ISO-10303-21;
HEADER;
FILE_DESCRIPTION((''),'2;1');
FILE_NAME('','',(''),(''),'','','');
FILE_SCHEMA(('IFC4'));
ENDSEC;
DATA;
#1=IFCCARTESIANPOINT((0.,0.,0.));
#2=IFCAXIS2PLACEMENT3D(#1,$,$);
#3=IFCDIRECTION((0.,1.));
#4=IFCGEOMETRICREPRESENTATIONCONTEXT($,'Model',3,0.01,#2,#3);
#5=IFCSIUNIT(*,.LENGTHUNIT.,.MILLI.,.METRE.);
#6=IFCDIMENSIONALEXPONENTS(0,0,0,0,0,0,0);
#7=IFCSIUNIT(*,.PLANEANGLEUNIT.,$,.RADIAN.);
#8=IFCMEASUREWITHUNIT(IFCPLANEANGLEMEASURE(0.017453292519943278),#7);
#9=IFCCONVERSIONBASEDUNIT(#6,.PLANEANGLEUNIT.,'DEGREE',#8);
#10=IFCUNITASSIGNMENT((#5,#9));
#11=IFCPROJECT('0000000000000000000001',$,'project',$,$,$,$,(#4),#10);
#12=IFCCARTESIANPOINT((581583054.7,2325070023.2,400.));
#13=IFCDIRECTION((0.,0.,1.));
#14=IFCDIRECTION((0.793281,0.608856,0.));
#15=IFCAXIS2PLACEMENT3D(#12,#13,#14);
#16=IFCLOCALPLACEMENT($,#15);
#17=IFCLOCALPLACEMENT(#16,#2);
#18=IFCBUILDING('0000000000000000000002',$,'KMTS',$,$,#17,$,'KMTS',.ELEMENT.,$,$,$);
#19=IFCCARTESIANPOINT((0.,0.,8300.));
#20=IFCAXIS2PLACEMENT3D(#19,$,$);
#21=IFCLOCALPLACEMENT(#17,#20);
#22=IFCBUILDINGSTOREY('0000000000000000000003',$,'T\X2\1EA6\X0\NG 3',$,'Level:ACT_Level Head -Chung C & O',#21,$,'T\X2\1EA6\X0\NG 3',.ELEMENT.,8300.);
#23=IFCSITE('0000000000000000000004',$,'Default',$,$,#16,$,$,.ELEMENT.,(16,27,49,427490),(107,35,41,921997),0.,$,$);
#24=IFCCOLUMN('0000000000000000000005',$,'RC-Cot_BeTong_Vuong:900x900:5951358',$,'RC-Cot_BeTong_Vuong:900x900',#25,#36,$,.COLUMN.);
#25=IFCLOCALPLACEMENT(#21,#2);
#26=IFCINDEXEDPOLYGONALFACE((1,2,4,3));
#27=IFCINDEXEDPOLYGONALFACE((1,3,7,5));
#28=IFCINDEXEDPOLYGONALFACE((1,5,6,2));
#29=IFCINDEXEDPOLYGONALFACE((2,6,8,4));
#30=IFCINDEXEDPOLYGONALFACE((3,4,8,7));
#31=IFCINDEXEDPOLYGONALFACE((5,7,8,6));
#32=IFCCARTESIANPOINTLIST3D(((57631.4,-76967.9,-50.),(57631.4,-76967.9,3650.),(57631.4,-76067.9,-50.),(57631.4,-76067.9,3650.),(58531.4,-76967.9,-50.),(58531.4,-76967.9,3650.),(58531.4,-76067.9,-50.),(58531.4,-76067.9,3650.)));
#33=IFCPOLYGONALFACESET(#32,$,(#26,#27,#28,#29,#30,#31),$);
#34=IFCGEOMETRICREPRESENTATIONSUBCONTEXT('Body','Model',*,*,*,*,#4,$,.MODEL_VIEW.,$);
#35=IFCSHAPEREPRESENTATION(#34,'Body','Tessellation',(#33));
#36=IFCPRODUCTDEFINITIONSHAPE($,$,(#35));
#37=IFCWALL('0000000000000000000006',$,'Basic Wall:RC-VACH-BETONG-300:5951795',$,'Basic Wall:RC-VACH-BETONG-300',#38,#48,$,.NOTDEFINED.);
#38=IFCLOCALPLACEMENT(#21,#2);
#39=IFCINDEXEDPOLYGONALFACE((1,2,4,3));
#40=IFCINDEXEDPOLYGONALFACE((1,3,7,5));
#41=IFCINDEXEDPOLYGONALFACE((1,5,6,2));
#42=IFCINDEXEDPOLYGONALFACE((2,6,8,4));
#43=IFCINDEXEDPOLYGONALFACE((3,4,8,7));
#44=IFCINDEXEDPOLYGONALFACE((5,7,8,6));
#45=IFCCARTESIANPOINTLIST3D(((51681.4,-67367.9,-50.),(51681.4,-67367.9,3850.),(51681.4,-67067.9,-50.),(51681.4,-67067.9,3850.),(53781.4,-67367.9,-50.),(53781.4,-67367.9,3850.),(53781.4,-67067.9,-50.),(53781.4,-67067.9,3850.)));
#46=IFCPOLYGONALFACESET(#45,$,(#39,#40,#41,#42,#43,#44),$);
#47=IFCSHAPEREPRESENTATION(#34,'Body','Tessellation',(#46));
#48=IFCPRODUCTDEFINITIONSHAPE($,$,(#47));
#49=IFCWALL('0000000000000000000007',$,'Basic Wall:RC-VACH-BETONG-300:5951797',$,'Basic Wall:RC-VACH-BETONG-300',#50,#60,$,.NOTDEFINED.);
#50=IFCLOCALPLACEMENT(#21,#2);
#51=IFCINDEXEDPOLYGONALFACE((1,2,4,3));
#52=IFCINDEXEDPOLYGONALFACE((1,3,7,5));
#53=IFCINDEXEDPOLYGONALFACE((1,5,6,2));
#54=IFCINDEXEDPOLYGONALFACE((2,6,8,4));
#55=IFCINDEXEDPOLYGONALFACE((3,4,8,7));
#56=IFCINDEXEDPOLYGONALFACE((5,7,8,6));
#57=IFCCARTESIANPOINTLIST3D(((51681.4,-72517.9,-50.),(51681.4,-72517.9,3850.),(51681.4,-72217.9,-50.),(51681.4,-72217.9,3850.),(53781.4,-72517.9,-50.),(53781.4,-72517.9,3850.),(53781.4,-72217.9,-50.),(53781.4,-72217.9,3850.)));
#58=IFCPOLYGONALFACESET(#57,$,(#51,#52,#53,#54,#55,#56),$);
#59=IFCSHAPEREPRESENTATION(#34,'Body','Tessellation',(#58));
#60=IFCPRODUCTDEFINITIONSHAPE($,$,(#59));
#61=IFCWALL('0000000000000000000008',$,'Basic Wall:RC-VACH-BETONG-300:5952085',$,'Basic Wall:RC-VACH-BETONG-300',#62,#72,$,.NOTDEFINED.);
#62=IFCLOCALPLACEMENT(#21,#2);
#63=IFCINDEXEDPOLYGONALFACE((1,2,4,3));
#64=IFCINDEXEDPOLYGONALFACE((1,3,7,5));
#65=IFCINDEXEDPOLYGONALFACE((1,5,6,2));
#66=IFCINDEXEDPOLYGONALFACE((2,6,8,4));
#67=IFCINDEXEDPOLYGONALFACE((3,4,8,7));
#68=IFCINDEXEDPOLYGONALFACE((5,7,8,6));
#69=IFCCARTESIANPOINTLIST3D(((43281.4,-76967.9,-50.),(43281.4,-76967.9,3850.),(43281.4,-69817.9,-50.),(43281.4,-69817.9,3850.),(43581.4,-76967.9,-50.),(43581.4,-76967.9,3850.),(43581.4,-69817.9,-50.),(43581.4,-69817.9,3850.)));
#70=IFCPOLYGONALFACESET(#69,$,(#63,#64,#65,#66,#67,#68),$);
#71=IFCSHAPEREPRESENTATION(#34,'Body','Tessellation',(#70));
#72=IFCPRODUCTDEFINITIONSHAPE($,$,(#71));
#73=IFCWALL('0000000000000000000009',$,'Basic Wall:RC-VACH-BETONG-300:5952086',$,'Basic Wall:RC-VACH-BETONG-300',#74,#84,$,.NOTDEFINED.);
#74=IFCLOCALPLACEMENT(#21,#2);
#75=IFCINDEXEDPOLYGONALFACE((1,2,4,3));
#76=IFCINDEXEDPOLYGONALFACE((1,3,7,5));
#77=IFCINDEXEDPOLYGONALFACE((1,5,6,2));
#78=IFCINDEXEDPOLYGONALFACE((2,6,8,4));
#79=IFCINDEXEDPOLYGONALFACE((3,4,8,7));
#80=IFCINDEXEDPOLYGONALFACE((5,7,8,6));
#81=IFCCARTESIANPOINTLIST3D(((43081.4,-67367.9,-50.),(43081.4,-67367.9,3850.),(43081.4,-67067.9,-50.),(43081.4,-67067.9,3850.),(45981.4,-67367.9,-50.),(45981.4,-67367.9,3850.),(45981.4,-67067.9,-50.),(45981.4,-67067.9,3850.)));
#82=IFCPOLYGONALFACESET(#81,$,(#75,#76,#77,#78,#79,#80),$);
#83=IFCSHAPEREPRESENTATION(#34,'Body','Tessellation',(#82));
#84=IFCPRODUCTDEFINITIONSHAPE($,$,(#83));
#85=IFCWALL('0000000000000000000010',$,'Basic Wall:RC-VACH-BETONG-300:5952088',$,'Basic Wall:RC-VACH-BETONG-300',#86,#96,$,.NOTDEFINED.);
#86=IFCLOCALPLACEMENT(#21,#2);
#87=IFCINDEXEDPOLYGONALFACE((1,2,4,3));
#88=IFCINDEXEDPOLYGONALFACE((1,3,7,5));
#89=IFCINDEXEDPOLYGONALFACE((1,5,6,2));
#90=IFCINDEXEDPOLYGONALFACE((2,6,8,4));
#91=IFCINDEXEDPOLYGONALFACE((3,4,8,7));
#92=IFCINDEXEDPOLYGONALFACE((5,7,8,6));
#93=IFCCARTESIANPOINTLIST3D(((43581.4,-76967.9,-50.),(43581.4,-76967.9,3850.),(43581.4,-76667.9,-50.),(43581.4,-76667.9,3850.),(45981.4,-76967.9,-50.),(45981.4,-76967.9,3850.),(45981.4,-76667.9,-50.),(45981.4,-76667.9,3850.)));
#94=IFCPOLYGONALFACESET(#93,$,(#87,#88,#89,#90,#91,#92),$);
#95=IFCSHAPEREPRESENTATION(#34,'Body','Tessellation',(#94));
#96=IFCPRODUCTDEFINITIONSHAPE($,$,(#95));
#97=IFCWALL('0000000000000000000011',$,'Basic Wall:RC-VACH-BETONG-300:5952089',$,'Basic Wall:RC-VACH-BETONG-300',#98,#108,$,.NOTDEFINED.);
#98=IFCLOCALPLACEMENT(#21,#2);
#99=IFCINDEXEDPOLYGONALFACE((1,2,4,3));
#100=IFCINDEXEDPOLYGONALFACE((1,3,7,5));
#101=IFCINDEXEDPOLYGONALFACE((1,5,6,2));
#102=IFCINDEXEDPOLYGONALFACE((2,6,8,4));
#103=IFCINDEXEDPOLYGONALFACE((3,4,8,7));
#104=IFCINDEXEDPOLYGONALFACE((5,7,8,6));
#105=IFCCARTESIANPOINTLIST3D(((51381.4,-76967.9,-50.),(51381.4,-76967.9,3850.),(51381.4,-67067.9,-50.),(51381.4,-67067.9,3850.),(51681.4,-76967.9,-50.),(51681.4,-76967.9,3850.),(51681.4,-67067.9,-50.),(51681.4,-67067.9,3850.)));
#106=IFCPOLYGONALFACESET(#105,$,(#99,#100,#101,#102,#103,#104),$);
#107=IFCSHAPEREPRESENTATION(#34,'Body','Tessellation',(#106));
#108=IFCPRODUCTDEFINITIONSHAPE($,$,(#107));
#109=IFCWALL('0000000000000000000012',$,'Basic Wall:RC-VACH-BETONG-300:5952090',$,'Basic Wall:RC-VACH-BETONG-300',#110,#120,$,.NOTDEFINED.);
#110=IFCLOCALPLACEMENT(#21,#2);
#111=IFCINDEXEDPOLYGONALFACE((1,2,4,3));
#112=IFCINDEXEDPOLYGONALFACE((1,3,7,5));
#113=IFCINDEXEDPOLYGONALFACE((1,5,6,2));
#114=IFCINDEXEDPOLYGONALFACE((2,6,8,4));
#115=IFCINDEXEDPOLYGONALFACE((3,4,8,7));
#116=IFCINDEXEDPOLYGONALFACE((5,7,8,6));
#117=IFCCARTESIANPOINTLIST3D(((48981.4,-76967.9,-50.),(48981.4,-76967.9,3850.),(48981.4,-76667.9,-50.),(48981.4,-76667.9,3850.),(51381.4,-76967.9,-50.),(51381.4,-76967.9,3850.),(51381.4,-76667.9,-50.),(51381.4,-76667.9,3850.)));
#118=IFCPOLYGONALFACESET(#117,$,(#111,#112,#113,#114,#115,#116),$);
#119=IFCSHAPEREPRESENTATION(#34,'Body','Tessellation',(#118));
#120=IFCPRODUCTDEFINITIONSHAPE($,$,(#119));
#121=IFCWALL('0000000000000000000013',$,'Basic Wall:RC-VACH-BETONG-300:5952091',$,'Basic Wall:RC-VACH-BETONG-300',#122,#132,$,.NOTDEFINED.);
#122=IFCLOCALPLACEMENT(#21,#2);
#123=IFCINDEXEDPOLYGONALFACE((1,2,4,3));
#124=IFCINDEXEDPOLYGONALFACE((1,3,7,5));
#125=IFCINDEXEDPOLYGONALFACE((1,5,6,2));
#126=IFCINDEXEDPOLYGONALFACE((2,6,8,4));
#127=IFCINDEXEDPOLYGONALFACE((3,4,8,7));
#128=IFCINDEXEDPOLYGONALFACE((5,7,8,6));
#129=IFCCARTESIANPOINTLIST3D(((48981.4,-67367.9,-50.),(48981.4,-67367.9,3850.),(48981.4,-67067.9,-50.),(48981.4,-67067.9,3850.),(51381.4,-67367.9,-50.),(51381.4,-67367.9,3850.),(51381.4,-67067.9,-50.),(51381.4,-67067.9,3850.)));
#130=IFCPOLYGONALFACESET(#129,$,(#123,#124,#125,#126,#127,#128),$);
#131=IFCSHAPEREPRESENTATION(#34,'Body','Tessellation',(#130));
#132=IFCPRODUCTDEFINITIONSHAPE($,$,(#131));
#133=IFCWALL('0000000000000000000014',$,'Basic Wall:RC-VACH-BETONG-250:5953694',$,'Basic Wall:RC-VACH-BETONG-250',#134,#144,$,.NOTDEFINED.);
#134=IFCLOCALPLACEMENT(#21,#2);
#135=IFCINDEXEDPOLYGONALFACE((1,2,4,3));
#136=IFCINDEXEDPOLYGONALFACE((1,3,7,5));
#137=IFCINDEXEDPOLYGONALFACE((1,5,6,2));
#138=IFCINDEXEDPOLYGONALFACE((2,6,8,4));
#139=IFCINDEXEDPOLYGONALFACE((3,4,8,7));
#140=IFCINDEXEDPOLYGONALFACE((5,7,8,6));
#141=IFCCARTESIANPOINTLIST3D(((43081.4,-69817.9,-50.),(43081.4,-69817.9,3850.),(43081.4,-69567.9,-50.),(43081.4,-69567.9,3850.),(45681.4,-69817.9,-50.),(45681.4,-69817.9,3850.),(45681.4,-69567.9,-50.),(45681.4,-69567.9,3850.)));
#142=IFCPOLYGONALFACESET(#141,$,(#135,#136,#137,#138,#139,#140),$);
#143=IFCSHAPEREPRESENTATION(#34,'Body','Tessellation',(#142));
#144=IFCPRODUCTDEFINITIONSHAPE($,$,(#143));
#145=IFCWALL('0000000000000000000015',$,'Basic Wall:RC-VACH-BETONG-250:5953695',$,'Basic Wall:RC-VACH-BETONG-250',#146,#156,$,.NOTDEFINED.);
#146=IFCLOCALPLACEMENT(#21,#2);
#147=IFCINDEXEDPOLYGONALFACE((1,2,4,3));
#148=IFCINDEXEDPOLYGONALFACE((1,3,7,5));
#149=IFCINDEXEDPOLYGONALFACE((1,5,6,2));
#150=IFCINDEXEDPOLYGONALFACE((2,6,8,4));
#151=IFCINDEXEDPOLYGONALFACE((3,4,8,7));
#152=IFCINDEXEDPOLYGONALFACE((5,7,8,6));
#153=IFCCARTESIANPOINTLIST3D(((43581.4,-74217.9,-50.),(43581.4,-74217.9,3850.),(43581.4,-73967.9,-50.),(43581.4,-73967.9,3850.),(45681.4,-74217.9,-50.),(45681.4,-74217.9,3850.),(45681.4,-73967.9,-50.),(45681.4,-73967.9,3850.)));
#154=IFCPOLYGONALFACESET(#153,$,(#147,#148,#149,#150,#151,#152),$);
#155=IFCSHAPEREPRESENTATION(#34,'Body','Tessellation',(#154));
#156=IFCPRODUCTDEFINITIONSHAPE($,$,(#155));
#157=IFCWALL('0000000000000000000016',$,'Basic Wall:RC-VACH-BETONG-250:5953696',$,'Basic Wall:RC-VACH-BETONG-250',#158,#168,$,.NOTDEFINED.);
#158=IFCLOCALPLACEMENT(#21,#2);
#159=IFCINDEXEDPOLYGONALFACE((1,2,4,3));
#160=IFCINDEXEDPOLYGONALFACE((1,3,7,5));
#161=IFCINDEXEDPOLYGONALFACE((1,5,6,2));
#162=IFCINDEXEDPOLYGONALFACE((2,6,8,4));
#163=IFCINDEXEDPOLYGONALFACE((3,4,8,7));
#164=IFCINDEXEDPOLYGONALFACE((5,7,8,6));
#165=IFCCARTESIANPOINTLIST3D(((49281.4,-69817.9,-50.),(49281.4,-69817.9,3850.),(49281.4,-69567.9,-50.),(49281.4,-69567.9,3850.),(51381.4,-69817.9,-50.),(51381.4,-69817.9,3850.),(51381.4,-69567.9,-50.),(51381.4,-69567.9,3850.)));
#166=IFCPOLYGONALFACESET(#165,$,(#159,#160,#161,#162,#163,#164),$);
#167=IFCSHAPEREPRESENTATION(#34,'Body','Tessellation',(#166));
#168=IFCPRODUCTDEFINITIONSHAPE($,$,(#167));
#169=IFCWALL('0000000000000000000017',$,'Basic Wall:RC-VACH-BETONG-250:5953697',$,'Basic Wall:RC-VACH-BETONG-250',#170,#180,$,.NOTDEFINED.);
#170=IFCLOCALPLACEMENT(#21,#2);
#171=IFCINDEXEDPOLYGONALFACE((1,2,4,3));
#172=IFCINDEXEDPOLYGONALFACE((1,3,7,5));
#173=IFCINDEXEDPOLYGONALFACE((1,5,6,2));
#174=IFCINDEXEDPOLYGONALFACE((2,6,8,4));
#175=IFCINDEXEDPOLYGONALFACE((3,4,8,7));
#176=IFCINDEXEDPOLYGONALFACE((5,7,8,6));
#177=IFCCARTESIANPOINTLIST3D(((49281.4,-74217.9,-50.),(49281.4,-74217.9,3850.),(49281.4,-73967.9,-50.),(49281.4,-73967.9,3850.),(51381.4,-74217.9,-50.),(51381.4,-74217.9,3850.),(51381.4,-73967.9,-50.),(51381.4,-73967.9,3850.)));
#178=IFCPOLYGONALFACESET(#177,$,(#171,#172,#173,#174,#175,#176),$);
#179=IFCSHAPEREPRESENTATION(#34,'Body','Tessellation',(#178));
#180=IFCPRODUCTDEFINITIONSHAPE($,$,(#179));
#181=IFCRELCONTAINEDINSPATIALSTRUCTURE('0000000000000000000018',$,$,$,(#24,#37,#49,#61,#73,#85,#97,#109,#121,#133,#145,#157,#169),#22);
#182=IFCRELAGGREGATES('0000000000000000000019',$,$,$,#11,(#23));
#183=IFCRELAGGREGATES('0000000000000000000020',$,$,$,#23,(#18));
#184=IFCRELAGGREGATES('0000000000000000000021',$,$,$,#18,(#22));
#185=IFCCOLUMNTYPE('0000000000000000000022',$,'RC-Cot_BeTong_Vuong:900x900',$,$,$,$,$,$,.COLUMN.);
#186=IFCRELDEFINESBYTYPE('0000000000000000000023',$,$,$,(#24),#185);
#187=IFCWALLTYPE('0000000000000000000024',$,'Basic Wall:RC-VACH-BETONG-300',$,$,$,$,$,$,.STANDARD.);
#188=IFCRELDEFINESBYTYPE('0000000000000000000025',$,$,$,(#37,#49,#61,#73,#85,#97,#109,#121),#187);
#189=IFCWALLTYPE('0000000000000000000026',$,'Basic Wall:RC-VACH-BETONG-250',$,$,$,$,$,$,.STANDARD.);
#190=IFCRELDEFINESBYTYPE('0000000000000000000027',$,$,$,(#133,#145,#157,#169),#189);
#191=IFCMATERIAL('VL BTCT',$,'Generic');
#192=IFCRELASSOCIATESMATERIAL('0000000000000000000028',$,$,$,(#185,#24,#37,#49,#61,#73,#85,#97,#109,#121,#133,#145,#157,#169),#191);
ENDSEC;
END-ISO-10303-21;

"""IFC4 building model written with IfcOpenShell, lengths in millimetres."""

from ifc_helpers import new_model, entity, si_unit, converted_unit, direction, frame, origin, place, context, subcontext, project, spatial, indexed_curve, outline, extrude, source, transform, mapped, material, type_object, type_shapes, element, save


model = new_model("IFC4")

# Units and contexts
model_context = context("Model", 3, precision=0.01, world=origin(), true_north=direction((0.0, 1.0)))
body_context = subcontext(model_context, "Body", "Model", "MODEL_VIEW")
ifc_project = project(units=[si_unit("LENGTHUNIT", "METRE", prefix="MILLI"), converted_unit("PLANEANGLEUNIT", "DEGREE", entity("IfcPlaneAngleMeasure", 0.017453292519943278), si_unit("PLANEANGLEUNIT", "RADIAN"), dimensions=[0, 0, 0, 0, 0, 0, 0])], contexts=[model_context])

# Site, building, storey
site_placement = place(None, frame((581583054.7, 2325070023.2, 400.0), z_axis=(0.0, 0.0, 1.0), x_axis=(0.793281, 0.608856, 0.0)))
site = spatial("IfcSite", under=ifc_project, at=site_placement, Name="Default", CompositionType="ELEMENT", RefLatitude=(16, 27, 49, 427490), RefLongitude=(107, 35, 41, 921997), RefElevation=0.0)
building_placement = place(site_placement, origin())
building = spatial("IfcBuilding", under=site, at=building_placement, Name="KMTS", LongName="KMTS", CompositionType="ELEMENT")
storey_placement = place(building_placement, frame((0.0, 0.0, 8300.0)))
storey = spatial("IfcBuildingStorey", under=building, at=storey_placement, Name="TẦNG 3", ObjectType="Level:ACT_Level Head -Chung C & O", LongName="TẦNG 3", CompositionType="ELEMENT", Elevation=8300.0)

# Column
ifc_material_1 = material(Name="VL BTCT", Category="Generic")
column_type_1 = type_object("IfcColumnType", Name="RC-Cot_BeTong_Vuong:900x900", PredefinedType="COLUMN", material=ifc_material_1)
shared_shape_1 = source(origin(), body_context, "Body", "SweptSolid", [
    extrude(outline(indexed_curve([(-450.0, -450.0), (450.0, -450.0), (450.0, 450.0), (-450.0, 450.0), (-450.0, -450.0)], self_intersect=False)), frame((58081.4, -76517.9, 8250.0), z_axis=(0.0, 0.0, 1.0), x_axis=(-1.0, 0.0, 0.0)), (0.0, 0.0, 1.0), 3700.0),
])
type_shapes(column_type_1, [shared_shape_1])
column_1_placement = place(storey_placement, frame((0.0, 0.0, -8300.0)))
element("IfcColumn", 1, at=column_1_placement, inside=storey, type_object=column_type_1, material=ifc_material_1, Name="RC-Cot_BeTong_Vuong:900x900:5951358", ObjectType="RC-Cot_BeTong_Vuong:900x900", PredefinedType="COLUMN", context=body_context, shape_type="MappedRepresentation", body=[
    mapped(shared_shape_1, transform((0.0, 0.0, 0.0), scale=1.0)),
])

# Walls
wall_type_1 = type_object("IfcWallType", Name="Basic Wall:RC-VACH-BETONG-300", PredefinedType="STANDARD")
wall_1_placement = place(storey_placement, frame((53781.4, -67217.9, -50.0), z_axis=(0.0, 0.0, 1.0), x_axis=(-1.0, 0.0, 0.0)))
element("IfcWall", 2, at=wall_1_placement, inside=storey, type_object=wall_type_1, material=ifc_material_1, Name="Basic Wall:RC-VACH-BETONG-300:5951795", ObjectType="Basic Wall:RC-VACH-BETONG-300", PredefinedType="NOTDEFINED", context=body_context, shape_type="SweptSolid", body=[
    extrude(outline(indexed_curve([(2100.0, 150.0), (0.0, 150.0), (0.0, -150.0), (2100.0, -150.0), (2100.0, 150.0)], self_intersect=False)), origin(), (0.0, 0.0, 1.0), 3900.0),
])
wall_2_placement = place(storey_placement, frame((53781.4, -72367.9, -50.0), z_axis=(0.0, 0.0, 1.0), x_axis=(-1.0, 0.0, 0.0)))
element("IfcWall", 3, at=wall_2_placement, inside=storey, type_object=wall_type_1, material=ifc_material_1, Name="Basic Wall:RC-VACH-BETONG-300:5951797", ObjectType="Basic Wall:RC-VACH-BETONG-300", PredefinedType="NOTDEFINED", context=body_context, shape_type="SweptSolid", body=[
    extrude(outline(indexed_curve([(2100.0, 150.0), (0.0, 150.0), (0.0, -150.0), (2100.0, -150.0), (2100.0, 150.0)], self_intersect=False)), origin(), (0.0, 0.0, 1.0), 3900.0),
])
wall_3_placement = place(storey_placement, frame((43431.4, -69817.9, -50.0), z_axis=(0.0, 0.0, 1.0), x_axis=(0.0, -1.0, 0.0)))
element("IfcWall", 4, at=wall_3_placement, inside=storey, type_object=wall_type_1, material=ifc_material_1, Name="Basic Wall:RC-VACH-BETONG-300:5952085", ObjectType="Basic Wall:RC-VACH-BETONG-300", PredefinedType="NOTDEFINED", context=body_context, shape_type="SweptSolid", body=[
    extrude(outline(indexed_curve([(7150.0, 150.0), (0.0, 150.0), (0.0, -150.0), (7150.0, -150.0), (7150.0, 150.0)], self_intersect=False)), origin(), (0.0, 0.0, 1.0), 3900.0),
])
wall_4_placement = place(storey_placement, frame((45981.4, -67217.9, -50.0), z_axis=(0.0, 0.0, 1.0), x_axis=(-1.0, 0.0, 0.0)))
element("IfcWall", 5, at=wall_4_placement, inside=storey, type_object=wall_type_1, material=ifc_material_1, Name="Basic Wall:RC-VACH-BETONG-300:5952086", ObjectType="Basic Wall:RC-VACH-BETONG-300", PredefinedType="NOTDEFINED", context=body_context, shape_type="SweptSolid", body=[
    extrude(outline(indexed_curve([(2900.0, 150.0), (0.0, 150.0), (0.0, -150.0), (2900.0, -150.0), (2900.0, 150.0)], self_intersect=False)), origin(), (0.0, 0.0, 1.0), 3900.0),
])
wall_5_placement = place(storey_placement, frame((45981.4, -76817.9, -50.0), z_axis=(0.0, 0.0, 1.0), x_axis=(-1.0, 0.0, 0.0)))
element("IfcWall", 6, at=wall_5_placement, inside=storey, type_object=wall_type_1, material=ifc_material_1, Name="Basic Wall:RC-VACH-BETONG-300:5952088", ObjectType="Basic Wall:RC-VACH-BETONG-300", PredefinedType="NOTDEFINED", context=body_context, shape_type="SweptSolid", body=[
    extrude(outline(indexed_curve([(2400.0, 150.0), (0.0, 150.0), (0.0, -150.0), (2400.0, -150.0), (2400.0, 150.0)], self_intersect=False)), origin(), (0.0, 0.0, 1.0), 3900.0),
])
wall_6_placement = place(storey_placement, frame((51531.4, -67067.9, -50.0), z_axis=(0.0, 0.0, 1.0), x_axis=(0.0, -1.0, 0.0)))
element("IfcWall", 7, at=wall_6_placement, inside=storey, type_object=wall_type_1, material=ifc_material_1, Name="Basic Wall:RC-VACH-BETONG-300:5952089", ObjectType="Basic Wall:RC-VACH-BETONG-300", PredefinedType="NOTDEFINED", context=body_context, shape_type="SweptSolid", body=[
    extrude(outline(indexed_curve([(9900.0, 150.0), (0.0, 150.0), (0.0, -150.0), (9900.0, -150.0), (9900.0, 150.0)], self_intersect=False)), origin(), (0.0, 0.0, 1.0), 3900.0),
])
wall_7_placement = place(storey_placement, frame((51381.4, -76817.9, -50.0), z_axis=(0.0, 0.0, 1.0), x_axis=(-1.0, 0.0, 0.0)))
element("IfcWall", 8, at=wall_7_placement, inside=storey, type_object=wall_type_1, material=ifc_material_1, Name="Basic Wall:RC-VACH-BETONG-300:5952090", ObjectType="Basic Wall:RC-VACH-BETONG-300", PredefinedType="NOTDEFINED", context=body_context, shape_type="SweptSolid", body=[
    extrude(outline(indexed_curve([(2400.0, 150.0), (0.0, 150.0), (0.0, -150.0), (2400.0, -150.0), (2400.0, 150.0)], self_intersect=False)), origin(), (0.0, 0.0, 1.0), 3900.0),
])
wall_8_placement = place(storey_placement, frame((51381.4, -67217.9, -50.0), z_axis=(0.0, 0.0, 1.0), x_axis=(-1.0, 0.0, 0.0)))
element("IfcWall", 9, at=wall_8_placement, inside=storey, type_object=wall_type_1, material=ifc_material_1, Name="Basic Wall:RC-VACH-BETONG-300:5952091", ObjectType="Basic Wall:RC-VACH-BETONG-300", PredefinedType="NOTDEFINED", context=body_context, shape_type="SweptSolid", body=[
    extrude(outline(indexed_curve([(2400.0, 150.0), (0.0, 150.0), (0.0, -150.0), (2400.0, -150.0), (2400.0, 150.0)], self_intersect=False)), origin(), (0.0, 0.0, 1.0), 3900.0),
])
wall_type_2 = type_object("IfcWallType", Name="Basic Wall:RC-VACH-BETONG-250", PredefinedType="STANDARD")
wall_9_placement = place(storey_placement, frame((45681.4, -69692.9, -50.0), z_axis=(0.0, 0.0, 1.0), x_axis=(-1.0, 0.0, 0.0)))
element("IfcWall", 10, at=wall_9_placement, inside=storey, type_object=wall_type_2, material=ifc_material_1, Name="Basic Wall:RC-VACH-BETONG-250:5953694", ObjectType="Basic Wall:RC-VACH-BETONG-250", PredefinedType="NOTDEFINED", context=body_context, shape_type="SweptSolid", body=[
    extrude(outline(indexed_curve([(2600.0, 125.0), (0.0, 125.0), (0.0, -125.0), (2600.0, -125.0), (2600.0, 125.0)], self_intersect=False)), origin(), (0.0, 0.0, 1.0), 3900.0),
])
wall_10_placement = place(storey_placement, frame((45681.4, -74092.9, -50.0), z_axis=(0.0, 0.0, 1.0), x_axis=(-1.0, 0.0, 0.0)))
element("IfcWall", 11, at=wall_10_placement, inside=storey, type_object=wall_type_2, material=ifc_material_1, Name="Basic Wall:RC-VACH-BETONG-250:5953695", ObjectType="Basic Wall:RC-VACH-BETONG-250", PredefinedType="NOTDEFINED", context=body_context, shape_type="SweptSolid", body=[
    extrude(outline(indexed_curve([(2100.0, 125.0), (0.0, 125.0), (0.0, -125.0), (2100.0, -125.0), (2100.0, 125.0)], self_intersect=False)), origin(), (0.0, 0.0, 1.0), 3900.0),
])
for number, where, z_axis, x_axis, name in (
    (12, (51381.4, -69692.9, -50.0), (0.0, 0.0, 1.0), (-1.0, 0.0, 0.0), "Basic Wall:RC-VACH-BETONG-250:5953696"),
    (13, (51381.4, -74092.9, -50.0), (0.0, 0.0, 1.0), (-1.0, 0.0, 0.0), "Basic Wall:RC-VACH-BETONG-250:5953697"),
):
    element("IfcWall", number, at=place(storey_placement, frame(where, z_axis=z_axis, x_axis=x_axis)), inside=storey, type_object=wall_type_2, material=ifc_material_1, Name=name, ObjectType="Basic Wall:RC-VACH-BETONG-250", PredefinedType="NOTDEFINED", context=body_context, shape_type="SweptSolid", body=[
        extrude(outline(indexed_curve([(2100.0, 125.0), (0.0, 125.0), (0.0, -125.0), (2100.0, -125.0), (2100.0, 125.0)], self_intersect=False)), origin(), (0.0, 0.0, 1.0), 3900.0),
    ])

save(model, "model.ifc")
